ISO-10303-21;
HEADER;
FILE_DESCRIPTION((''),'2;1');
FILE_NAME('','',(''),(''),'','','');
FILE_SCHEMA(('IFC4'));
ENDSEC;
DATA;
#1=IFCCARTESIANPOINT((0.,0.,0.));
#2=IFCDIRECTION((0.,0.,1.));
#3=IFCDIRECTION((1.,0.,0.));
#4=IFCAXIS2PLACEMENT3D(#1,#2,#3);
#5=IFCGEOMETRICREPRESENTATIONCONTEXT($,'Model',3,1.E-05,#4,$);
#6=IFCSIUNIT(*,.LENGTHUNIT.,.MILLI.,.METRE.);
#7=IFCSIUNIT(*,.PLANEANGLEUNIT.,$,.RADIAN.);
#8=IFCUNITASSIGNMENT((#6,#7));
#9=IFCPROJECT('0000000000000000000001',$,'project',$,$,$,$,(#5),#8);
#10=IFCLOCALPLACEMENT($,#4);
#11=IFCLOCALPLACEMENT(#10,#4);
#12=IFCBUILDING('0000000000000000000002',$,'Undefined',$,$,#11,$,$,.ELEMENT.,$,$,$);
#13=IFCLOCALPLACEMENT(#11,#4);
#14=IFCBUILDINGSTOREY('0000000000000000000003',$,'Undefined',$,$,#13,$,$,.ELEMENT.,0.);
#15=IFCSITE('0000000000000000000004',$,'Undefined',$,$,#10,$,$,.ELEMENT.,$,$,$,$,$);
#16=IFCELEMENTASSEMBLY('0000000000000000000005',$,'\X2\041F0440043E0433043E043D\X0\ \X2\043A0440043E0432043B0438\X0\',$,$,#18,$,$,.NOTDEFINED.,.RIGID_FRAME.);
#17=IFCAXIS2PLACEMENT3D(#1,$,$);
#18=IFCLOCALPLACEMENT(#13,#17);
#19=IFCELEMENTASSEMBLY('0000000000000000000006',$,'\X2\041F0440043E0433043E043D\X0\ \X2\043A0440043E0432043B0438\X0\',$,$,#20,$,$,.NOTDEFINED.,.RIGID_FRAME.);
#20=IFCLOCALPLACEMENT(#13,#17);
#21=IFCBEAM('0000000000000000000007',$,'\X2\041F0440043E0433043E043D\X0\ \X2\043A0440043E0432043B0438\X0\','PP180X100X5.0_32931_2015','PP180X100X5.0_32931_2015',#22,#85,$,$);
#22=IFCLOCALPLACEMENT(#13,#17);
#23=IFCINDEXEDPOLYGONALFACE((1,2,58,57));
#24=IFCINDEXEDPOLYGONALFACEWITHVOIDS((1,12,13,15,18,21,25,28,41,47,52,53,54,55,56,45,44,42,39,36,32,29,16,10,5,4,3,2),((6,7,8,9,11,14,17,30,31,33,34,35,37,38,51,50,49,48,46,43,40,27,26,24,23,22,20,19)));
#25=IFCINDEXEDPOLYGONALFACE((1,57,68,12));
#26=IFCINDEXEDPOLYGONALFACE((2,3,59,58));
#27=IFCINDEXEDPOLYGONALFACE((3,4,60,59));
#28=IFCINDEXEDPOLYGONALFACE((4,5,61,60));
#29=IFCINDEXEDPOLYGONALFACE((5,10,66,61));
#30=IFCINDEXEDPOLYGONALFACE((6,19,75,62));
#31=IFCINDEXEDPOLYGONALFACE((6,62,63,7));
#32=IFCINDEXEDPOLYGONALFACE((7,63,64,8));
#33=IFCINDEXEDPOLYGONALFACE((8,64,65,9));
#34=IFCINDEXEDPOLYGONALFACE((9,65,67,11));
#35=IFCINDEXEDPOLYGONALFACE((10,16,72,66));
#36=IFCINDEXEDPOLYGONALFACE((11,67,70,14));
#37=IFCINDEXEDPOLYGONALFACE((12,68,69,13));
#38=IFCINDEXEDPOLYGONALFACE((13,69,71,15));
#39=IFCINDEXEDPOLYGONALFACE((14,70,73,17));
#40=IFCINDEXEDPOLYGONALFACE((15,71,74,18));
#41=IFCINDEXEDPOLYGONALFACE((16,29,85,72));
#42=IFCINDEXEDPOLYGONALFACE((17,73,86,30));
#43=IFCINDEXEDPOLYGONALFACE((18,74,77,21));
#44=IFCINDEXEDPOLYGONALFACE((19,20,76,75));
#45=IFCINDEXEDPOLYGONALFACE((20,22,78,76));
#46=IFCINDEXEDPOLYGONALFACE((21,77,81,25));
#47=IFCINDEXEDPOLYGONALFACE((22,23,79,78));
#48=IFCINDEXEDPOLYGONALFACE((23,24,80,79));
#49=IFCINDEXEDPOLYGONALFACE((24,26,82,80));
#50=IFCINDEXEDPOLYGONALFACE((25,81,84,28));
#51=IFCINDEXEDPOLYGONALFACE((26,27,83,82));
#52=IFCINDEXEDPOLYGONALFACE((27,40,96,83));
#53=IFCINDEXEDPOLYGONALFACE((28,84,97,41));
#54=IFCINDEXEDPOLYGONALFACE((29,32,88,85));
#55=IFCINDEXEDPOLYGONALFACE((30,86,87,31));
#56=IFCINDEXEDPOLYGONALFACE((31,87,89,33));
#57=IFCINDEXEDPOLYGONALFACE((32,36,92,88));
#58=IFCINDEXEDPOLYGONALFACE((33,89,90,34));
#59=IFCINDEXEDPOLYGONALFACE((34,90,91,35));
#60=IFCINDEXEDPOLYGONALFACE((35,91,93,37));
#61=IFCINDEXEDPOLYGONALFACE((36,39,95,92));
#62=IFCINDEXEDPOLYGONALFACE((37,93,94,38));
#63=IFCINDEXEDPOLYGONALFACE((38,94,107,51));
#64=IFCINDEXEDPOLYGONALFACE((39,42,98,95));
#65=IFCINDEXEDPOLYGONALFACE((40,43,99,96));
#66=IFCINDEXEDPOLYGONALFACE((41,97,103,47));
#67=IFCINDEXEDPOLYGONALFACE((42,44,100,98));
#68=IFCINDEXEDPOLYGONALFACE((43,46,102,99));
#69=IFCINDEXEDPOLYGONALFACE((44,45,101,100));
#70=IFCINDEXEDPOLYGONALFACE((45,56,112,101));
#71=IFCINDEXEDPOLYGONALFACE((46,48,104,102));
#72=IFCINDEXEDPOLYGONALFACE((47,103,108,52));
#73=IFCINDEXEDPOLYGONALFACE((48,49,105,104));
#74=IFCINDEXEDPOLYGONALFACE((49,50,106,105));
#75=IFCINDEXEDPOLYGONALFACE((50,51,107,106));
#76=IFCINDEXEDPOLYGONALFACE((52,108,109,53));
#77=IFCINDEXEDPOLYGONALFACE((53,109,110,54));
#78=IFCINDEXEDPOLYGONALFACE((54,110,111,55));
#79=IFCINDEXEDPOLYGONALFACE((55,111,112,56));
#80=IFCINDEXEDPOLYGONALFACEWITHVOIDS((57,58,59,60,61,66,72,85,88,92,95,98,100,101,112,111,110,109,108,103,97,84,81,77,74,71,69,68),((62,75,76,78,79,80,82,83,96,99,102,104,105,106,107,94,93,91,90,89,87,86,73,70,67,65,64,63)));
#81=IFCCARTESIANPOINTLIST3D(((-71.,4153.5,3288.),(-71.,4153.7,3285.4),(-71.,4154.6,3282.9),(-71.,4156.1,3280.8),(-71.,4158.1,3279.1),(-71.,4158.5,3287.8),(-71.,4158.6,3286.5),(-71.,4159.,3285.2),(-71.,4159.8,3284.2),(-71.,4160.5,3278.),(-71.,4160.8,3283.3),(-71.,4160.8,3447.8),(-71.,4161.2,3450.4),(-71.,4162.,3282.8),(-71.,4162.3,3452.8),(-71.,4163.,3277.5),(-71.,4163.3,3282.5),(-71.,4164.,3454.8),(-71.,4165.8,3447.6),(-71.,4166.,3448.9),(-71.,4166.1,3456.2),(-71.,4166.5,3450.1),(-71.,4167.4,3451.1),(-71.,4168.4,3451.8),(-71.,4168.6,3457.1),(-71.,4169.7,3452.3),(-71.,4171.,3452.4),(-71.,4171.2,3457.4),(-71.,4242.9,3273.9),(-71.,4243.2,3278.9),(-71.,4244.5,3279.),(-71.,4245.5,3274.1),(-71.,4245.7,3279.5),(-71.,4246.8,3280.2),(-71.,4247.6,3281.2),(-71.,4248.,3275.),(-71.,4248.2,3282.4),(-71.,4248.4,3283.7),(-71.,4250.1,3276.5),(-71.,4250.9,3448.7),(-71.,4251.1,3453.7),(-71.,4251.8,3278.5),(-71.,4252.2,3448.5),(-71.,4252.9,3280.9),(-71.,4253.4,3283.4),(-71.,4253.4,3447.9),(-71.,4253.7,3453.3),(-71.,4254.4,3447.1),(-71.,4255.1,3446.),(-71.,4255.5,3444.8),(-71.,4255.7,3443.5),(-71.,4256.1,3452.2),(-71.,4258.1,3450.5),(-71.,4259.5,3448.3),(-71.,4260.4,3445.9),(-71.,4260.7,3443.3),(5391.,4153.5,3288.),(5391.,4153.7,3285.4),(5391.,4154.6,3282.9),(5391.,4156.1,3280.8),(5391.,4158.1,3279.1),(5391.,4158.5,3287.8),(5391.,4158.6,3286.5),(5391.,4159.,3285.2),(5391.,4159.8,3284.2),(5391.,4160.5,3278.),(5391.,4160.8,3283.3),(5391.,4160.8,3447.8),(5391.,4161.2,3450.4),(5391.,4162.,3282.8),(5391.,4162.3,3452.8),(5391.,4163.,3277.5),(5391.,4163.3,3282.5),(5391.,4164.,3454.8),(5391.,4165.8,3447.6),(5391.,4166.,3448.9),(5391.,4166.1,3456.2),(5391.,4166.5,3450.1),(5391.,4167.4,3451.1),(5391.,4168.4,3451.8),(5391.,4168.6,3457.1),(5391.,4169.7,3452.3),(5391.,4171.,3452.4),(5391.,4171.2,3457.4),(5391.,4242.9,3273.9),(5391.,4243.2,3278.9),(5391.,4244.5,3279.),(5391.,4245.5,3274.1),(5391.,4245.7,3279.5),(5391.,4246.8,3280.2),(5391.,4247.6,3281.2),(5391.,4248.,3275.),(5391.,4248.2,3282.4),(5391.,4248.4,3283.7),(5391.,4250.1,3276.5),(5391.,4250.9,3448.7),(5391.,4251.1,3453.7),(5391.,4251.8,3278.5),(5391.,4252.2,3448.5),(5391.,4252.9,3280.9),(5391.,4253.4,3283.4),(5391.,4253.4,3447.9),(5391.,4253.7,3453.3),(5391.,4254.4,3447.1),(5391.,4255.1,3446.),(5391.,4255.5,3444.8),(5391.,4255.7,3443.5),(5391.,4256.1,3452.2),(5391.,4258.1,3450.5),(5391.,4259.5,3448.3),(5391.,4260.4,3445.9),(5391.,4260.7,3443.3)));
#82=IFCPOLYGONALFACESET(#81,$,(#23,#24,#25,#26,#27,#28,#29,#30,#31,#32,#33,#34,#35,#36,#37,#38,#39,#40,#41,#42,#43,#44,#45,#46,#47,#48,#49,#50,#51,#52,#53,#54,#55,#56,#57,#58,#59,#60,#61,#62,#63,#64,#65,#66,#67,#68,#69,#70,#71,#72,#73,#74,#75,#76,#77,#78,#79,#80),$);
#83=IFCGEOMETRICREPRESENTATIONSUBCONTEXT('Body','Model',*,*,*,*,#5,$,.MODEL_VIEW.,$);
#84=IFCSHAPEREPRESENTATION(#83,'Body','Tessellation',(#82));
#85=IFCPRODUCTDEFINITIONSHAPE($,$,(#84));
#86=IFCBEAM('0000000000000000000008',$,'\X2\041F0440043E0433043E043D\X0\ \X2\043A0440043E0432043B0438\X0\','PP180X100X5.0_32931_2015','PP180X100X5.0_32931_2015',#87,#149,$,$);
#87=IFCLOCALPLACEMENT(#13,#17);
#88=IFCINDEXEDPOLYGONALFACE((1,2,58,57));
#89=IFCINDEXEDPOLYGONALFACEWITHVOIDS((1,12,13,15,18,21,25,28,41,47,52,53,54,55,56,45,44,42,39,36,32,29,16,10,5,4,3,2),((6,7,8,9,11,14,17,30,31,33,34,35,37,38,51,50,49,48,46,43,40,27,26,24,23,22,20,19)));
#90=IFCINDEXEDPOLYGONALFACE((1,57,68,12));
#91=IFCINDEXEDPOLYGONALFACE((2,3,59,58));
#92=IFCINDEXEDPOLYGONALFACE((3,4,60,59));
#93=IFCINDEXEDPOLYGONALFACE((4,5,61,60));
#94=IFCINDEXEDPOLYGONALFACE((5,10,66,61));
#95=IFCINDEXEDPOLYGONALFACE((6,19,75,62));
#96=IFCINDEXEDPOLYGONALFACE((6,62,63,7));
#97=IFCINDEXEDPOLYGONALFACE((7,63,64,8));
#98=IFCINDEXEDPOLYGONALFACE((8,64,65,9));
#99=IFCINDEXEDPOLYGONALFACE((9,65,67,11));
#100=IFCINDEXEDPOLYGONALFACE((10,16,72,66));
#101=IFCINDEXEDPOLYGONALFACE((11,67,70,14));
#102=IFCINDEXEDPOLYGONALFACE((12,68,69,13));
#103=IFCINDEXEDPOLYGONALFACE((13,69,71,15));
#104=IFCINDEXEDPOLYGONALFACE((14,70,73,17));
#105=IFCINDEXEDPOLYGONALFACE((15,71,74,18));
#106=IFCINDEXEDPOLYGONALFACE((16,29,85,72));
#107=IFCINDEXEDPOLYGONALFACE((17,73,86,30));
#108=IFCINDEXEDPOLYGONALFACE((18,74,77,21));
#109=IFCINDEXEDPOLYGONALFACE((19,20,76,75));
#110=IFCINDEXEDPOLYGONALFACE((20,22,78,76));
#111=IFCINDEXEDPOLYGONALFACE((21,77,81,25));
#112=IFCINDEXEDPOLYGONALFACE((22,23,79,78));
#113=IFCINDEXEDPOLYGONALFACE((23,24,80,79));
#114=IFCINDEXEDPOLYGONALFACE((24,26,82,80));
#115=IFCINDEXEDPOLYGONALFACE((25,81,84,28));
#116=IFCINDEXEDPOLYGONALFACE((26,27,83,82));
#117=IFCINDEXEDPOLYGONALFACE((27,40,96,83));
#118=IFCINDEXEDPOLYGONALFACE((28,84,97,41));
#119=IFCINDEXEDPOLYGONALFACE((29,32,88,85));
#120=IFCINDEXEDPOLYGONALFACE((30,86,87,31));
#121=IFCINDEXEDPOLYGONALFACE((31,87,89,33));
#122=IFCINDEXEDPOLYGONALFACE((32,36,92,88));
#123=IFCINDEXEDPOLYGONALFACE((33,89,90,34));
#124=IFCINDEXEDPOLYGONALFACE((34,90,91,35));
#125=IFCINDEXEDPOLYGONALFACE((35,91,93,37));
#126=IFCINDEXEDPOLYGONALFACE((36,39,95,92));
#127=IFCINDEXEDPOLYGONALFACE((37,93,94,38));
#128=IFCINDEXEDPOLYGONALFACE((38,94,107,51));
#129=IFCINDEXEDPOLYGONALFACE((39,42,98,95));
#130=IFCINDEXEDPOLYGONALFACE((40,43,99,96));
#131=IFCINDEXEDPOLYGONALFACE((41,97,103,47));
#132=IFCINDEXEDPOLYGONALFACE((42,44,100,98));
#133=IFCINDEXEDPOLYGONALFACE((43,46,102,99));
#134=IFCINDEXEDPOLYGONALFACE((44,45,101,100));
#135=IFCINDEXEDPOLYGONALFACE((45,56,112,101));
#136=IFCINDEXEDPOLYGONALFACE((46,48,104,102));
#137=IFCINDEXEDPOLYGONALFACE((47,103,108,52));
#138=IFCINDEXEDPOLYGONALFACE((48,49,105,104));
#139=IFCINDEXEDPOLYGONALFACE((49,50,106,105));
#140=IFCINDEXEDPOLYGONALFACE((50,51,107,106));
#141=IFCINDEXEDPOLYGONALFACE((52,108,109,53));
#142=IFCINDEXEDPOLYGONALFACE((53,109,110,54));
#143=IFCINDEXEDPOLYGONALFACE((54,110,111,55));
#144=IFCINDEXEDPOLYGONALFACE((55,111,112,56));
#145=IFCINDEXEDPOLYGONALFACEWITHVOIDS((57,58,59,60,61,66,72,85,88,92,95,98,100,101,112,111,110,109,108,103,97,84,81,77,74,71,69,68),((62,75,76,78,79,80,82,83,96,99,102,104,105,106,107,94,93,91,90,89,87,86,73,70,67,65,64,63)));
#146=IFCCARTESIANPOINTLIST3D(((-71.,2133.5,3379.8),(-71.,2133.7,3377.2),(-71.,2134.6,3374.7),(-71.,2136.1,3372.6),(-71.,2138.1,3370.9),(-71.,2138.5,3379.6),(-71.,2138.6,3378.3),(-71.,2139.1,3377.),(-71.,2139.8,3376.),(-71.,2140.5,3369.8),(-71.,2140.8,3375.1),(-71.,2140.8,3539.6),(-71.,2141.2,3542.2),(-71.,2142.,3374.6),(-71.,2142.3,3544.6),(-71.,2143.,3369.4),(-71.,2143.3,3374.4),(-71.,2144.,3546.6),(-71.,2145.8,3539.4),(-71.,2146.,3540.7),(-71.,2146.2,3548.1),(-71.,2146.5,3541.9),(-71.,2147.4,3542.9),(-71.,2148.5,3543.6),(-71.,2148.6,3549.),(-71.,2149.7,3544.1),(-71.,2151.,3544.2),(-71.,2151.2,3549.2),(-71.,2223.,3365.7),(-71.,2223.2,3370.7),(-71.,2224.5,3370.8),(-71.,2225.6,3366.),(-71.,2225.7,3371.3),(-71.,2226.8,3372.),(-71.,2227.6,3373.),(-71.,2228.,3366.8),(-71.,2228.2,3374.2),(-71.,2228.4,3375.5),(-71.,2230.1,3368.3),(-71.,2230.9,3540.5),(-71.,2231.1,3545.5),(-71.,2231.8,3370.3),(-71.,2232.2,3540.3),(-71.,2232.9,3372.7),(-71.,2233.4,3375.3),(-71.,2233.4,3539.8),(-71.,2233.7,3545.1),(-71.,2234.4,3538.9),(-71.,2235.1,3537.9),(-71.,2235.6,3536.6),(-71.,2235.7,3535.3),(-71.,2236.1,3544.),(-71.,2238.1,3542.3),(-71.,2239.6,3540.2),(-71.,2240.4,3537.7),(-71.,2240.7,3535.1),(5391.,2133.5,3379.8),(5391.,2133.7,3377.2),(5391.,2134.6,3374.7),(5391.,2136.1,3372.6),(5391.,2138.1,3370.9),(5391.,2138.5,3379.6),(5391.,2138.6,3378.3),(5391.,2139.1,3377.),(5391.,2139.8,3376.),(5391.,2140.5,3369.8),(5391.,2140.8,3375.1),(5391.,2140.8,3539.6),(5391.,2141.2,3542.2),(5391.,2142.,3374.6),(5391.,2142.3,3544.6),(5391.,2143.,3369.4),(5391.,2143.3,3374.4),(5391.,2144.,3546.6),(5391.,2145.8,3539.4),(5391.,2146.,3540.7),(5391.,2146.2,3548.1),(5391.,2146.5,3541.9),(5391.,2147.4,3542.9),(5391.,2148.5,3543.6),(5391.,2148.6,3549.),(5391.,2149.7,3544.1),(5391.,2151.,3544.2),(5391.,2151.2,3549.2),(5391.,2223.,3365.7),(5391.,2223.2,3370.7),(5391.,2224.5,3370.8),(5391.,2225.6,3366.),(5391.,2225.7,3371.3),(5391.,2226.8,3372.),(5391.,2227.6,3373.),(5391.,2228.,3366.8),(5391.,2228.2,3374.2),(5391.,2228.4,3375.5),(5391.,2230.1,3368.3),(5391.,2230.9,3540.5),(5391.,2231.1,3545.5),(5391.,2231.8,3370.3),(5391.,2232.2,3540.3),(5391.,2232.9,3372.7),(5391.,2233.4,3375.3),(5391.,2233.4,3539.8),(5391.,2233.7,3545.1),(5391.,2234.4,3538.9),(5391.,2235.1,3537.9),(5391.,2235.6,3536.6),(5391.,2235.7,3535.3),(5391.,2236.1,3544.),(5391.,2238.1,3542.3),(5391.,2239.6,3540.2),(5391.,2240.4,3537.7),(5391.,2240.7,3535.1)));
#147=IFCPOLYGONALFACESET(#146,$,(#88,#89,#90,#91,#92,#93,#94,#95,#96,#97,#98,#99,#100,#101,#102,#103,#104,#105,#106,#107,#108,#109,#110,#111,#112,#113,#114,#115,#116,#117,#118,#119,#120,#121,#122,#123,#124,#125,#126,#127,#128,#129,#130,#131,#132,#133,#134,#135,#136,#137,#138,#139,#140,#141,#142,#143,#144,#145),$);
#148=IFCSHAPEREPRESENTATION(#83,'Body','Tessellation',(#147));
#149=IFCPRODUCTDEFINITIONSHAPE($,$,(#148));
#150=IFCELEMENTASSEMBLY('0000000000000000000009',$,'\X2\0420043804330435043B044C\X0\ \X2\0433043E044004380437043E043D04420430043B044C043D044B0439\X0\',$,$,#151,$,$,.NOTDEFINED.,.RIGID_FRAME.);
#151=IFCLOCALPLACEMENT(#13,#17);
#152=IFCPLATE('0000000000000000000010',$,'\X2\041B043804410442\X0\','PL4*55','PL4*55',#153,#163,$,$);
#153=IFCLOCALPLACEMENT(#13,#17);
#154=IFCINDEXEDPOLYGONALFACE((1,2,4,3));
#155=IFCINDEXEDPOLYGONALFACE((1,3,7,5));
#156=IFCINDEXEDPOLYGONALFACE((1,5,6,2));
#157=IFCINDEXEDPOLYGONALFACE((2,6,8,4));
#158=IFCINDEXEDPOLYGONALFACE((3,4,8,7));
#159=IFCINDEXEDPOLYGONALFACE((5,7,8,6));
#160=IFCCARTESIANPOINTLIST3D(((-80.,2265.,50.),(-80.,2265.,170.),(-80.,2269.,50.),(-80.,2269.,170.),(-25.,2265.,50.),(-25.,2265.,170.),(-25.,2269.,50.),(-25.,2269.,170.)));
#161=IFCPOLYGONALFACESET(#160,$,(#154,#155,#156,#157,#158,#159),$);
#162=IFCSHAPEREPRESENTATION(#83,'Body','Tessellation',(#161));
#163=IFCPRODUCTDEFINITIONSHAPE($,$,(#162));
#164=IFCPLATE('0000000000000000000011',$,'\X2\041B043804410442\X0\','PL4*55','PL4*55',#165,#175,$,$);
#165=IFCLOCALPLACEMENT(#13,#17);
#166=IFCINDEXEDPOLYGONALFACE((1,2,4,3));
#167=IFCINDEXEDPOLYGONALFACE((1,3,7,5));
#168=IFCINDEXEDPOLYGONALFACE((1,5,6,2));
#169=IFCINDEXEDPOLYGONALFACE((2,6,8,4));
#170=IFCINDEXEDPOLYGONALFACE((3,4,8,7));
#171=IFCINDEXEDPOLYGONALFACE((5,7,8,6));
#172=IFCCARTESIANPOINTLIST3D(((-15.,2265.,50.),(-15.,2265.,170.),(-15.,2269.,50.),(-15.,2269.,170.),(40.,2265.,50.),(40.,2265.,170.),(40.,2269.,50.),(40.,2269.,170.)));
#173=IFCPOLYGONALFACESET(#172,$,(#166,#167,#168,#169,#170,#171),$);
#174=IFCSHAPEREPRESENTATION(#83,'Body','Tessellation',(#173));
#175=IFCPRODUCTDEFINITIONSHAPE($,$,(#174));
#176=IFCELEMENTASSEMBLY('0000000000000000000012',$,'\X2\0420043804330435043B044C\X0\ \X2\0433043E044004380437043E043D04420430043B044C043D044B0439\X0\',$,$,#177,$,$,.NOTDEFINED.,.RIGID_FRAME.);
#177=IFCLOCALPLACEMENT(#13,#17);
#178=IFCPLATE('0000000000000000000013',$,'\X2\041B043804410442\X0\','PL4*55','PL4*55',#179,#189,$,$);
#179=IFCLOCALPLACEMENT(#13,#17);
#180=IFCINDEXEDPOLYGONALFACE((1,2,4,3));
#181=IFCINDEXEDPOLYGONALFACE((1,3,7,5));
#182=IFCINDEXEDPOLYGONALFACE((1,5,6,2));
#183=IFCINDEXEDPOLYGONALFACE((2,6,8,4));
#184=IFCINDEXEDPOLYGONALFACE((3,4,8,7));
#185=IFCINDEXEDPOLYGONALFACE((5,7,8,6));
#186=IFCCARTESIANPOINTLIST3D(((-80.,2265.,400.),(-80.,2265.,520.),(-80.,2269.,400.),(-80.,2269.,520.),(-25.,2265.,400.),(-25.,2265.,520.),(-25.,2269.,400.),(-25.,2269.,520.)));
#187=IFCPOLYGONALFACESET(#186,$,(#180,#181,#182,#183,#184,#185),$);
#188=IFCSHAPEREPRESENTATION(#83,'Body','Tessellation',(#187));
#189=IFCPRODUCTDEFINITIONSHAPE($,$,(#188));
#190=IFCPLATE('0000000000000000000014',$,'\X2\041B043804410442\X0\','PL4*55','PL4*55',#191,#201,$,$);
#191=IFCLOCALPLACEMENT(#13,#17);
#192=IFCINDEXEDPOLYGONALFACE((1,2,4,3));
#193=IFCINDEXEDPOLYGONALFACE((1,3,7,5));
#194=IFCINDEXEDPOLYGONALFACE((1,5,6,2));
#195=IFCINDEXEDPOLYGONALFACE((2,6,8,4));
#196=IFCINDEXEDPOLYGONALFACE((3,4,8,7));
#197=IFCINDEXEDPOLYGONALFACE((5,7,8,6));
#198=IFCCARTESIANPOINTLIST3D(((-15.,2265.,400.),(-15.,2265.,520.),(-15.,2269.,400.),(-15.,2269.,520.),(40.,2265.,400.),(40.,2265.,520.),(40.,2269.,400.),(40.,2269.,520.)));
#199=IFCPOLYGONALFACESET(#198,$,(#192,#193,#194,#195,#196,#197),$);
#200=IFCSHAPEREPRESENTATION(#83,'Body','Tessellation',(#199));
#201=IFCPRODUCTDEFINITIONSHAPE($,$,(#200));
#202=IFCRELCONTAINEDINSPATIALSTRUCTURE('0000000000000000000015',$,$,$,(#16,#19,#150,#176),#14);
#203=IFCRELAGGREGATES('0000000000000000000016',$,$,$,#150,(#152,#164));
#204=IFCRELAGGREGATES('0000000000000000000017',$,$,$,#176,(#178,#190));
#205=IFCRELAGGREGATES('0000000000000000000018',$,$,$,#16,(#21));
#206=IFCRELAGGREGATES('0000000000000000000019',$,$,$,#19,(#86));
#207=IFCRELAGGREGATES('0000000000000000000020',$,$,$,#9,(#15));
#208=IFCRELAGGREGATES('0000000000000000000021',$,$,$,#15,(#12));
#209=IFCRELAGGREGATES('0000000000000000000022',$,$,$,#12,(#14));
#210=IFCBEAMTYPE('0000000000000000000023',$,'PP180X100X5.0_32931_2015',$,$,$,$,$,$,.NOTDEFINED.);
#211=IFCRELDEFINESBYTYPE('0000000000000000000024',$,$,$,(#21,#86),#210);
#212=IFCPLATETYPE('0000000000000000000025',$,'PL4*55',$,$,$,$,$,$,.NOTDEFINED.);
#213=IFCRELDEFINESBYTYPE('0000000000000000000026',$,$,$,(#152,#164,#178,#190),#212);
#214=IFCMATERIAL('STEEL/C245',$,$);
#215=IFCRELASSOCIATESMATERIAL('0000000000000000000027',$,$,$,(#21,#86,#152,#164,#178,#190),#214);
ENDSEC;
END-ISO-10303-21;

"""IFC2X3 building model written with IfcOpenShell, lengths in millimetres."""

from ifc_helpers import new_model, si_unit, frame, origin_with_axes, origin_2d_with_axis, place, context, subcontext, project, spatial, polyline, hollow_rectangle, outline, extrude, clip, halfspace, material, type_object, element, aggregate, save


model = new_model("IFC2X3")

# Units and contexts
model_context = context("Model", 3, precision=1e-05, world=origin_with_axes())
body_context = subcontext(model_context, "Body", "Model", "MODEL_VIEW")
ifc_project = project(units=[si_unit("LENGTHUNIT", "METRE", prefix="MILLI"), si_unit("PLANEANGLEUNIT", "RADIAN")], contexts=[model_context])

# Site, building, storey
site_placement = place(None, origin_with_axes())
site = spatial("IfcSite", under=ifc_project, at=site_placement, Name="Undefined", CompositionType="ELEMENT")
building_placement = place(site_placement, origin_with_axes())
building = spatial("IfcBuilding", under=site, at=building_placement, Name="Undefined", CompositionType="ELEMENT")
storey_placement = place(building_placement, origin_with_axes())
storey = spatial("IfcBuildingStorey", under=building, at=storey_placement, Name="Undefined", CompositionType="ELEMENT", Elevation=0.0)

# Shared definitions
ifc_material_1 = material(Name="STEEL/C245")

# Element assemblies
assembly_1_placement = place(storey_placement, origin_with_axes())
assembly_1 = element("IfcElementAssembly", 1, at=assembly_1_placement, inside=storey, Name="Прогон кровли", AssemblyPlace="NOTDEFINED", PredefinedType="RIGID_FRAME")
assembly_2_placement = place(storey_placement, origin_with_axes())
assembly_2 = element("IfcElementAssembly", 2, at=assembly_2_placement, inside=storey, Name="Прогон кровли", AssemblyPlace="NOTDEFINED", PredefinedType="RIGID_FRAME")

# Beams
beam_type_1 = type_object("IfcBeamType", Name="PP180X100X5.0_32931_2015", PredefinedType="NOTDEFINED")
beam_1_placement = place(assembly_1_placement, frame((-595.0, 4207.1, 3365.6), z_axis=(0.0, 0.045408, 0.998969), x_axis=(1.0, 0.0, 0.0)))
beam_1 = element("IfcBeam", 3, at=beam_1_placement, type_object=beam_type_1, material=ifc_material_1, Name="Прогон кровли", Description="PP180X100X5.0_32931_2015", ObjectType="PP180X100X5.0_32931_2015", context=body_context, shape_type="Clipping", body=[
    clip(clip(extrude(hollow_rectangle(XDim=100.0, YDim=180.0, WallThickness=5.0, InnerFilletRadius=5.0, OuterFilletRadius=10.0, at=origin_2d_with_axis()), frame((5986.0, 0.0, 0.0), z_axis=(-1.0, 0.0, 0.0), x_axis=(0.0, -1.0, 0.0)), (0.0, 0.0, 1.0), 5462.0), halfspace(frame((5986.0, 0.0, -90.0), z_axis=(-1.0, 0.0, 0.0), x_axis=(0.0, 1.0, 0.0)), True)), halfspace(frame((524.0, 0.0, -90.0), z_axis=(1.0, 0.0, 0.0), x_axis=(0.0, -1.0, 0.0)), True)),
])
beam_2_placement = place(assembly_2_placement, frame((-595.0, 2187.1, 3457.5), z_axis=(0.0, 0.045408, 0.998969), x_axis=(1.0, 0.0, 0.0)))
beam_2 = element("IfcBeam", 4, at=beam_2_placement, type_object=beam_type_1, material=ifc_material_1, Name="Прогон кровли", Description="PP180X100X5.0_32931_2015", ObjectType="PP180X100X5.0_32931_2015", context=body_context, shape_type="Clipping", body=[
    clip(clip(extrude(hollow_rectangle(XDim=100.0, YDim=180.0, WallThickness=5.0, InnerFilletRadius=5.0, OuterFilletRadius=10.0, at=origin_2d_with_axis()), frame((5986.0, 0.0, 0.0), z_axis=(-1.0, 0.0, 0.0), x_axis=(0.0, -1.0, 0.0)), (0.0, 0.0, 1.0), 5462.0), halfspace(frame((5986.0, 0.0, -90.0), z_axis=(-1.0, 0.0, 0.0), x_axis=(0.0, 1.0, 0.0)), True)), halfspace(frame((524.0, 0.0, -90.0), z_axis=(1.0, 0.0, 0.0), x_axis=(0.0, -1.0, 0.0)), True)),
])

# Element assemblies, plates
assembly_3_placement = place(storey_placement, origin_with_axes())
assembly_3 = element("IfcElementAssembly", 5, at=assembly_3_placement, inside=storey, Name="Ригель горизонтальный", AssemblyPlace="NOTDEFINED", PredefinedType="RIGID_FRAME")
plate_type_1 = type_object("IfcPlateType", Name="PL4*55", PredefinedType="NOTDEFINED")
plate_1_placement = place(assembly_3_placement, frame((-52.5, 2267.0, 50.0), z_axis=(0.0, 1.0, 0.0), x_axis=(0.0, 0.0, 1.0)))
plate_1 = element("IfcPlate", 6, at=plate_1_placement, type_object=plate_type_1, material=ifc_material_1, Name="Лист", Description="PL4*55", ObjectType="PL4*55", context=body_context, shape_type="SweptSolid", body=[
    extrude(outline(polyline([(0.0, -27.5), (0.0, 27.5), (120.0, 27.5), (120.0, -27.5), (0.0, -27.5)])), frame((0.0, 0.0, -2.0), z_axis=(0.0, 0.0, 1.0), x_axis=(1.0, 0.0, 0.0)), (0.0, 0.0, 1.0), 4.0),
])
plate_2_placement = place(assembly_3_placement, frame((12.5, 2267.0, 50.0), z_axis=(0.0, -1.0, 0.0), x_axis=(0.0, 0.0, 1.0)))
plate_2 = element("IfcPlate", 7, at=plate_2_placement, type_object=plate_type_1, material=ifc_material_1, Name="Лист", Description="PL4*55", ObjectType="PL4*55", context=body_context, shape_type="SweptSolid", body=[
    extrude(outline(polyline([(0.0, 27.5), (120.0, 27.5), (120.0, -27.5), (0.0, -27.5), (0.0, 27.5)])), frame((0.0, 0.0, -2.0), z_axis=(0.0, 0.0, 1.0), x_axis=(1.0, 0.0, 0.0)), (0.0, 0.0, 1.0), 4.0),
])
assembly_4_placement = place(storey_placement, origin_with_axes())
assembly_4 = element("IfcElementAssembly", 8, at=assembly_4_placement, inside=storey, Name="Ригель горизонтальный", AssemblyPlace="NOTDEFINED", PredefinedType="RIGID_FRAME")
plate_3_placement = place(assembly_4_placement, frame((-52.5, 2267.0, 400.0), z_axis=(0.0, 1.0, 0.0), x_axis=(0.0, 0.0, 1.0)))
plate_3 = element("IfcPlate", 9, at=plate_3_placement, type_object=plate_type_1, material=ifc_material_1, Name="Лист", Description="PL4*55", ObjectType="PL4*55", context=body_context, shape_type="SweptSolid", body=[
    extrude(outline(polyline([(0.0, -27.5), (0.0, 27.5), (120.0, 27.5), (120.0, -27.5), (0.0, -27.5)])), frame((0.0, 0.0, -2.0), z_axis=(0.0, 0.0, 1.0), x_axis=(1.0, 0.0, 0.0)), (0.0, 0.0, 1.0), 4.0),
])
plate_4_placement = place(assembly_4_placement, frame((12.5, 2267.0, 400.0), z_axis=(0.0, -1.0, 0.0), x_axis=(0.0, 0.0, 1.0)))
plate_4 = element("IfcPlate", 10, at=plate_4_placement, type_object=plate_type_1, material=ifc_material_1, Name="Лист", Description="PL4*55", ObjectType="PL4*55", context=body_context, shape_type="SweptSolid", body=[
    extrude(outline(polyline([(0.0, 27.5), (120.0, 27.5), (120.0, -27.5), (0.0, -27.5), (0.0, 27.5)])), frame((0.0, 0.0, -2.0), z_axis=(0.0, 0.0, 1.0), x_axis=(1.0, 0.0, 0.0)), (0.0, 0.0, 1.0), 4.0),
])

aggregate(assembly_3, [plate_1, plate_2])
aggregate(assembly_4, [plate_3, plate_4])
aggregate(assembly_1, [beam_1])
aggregate(assembly_2, [beam_2])

save(model, "model.ifc")
